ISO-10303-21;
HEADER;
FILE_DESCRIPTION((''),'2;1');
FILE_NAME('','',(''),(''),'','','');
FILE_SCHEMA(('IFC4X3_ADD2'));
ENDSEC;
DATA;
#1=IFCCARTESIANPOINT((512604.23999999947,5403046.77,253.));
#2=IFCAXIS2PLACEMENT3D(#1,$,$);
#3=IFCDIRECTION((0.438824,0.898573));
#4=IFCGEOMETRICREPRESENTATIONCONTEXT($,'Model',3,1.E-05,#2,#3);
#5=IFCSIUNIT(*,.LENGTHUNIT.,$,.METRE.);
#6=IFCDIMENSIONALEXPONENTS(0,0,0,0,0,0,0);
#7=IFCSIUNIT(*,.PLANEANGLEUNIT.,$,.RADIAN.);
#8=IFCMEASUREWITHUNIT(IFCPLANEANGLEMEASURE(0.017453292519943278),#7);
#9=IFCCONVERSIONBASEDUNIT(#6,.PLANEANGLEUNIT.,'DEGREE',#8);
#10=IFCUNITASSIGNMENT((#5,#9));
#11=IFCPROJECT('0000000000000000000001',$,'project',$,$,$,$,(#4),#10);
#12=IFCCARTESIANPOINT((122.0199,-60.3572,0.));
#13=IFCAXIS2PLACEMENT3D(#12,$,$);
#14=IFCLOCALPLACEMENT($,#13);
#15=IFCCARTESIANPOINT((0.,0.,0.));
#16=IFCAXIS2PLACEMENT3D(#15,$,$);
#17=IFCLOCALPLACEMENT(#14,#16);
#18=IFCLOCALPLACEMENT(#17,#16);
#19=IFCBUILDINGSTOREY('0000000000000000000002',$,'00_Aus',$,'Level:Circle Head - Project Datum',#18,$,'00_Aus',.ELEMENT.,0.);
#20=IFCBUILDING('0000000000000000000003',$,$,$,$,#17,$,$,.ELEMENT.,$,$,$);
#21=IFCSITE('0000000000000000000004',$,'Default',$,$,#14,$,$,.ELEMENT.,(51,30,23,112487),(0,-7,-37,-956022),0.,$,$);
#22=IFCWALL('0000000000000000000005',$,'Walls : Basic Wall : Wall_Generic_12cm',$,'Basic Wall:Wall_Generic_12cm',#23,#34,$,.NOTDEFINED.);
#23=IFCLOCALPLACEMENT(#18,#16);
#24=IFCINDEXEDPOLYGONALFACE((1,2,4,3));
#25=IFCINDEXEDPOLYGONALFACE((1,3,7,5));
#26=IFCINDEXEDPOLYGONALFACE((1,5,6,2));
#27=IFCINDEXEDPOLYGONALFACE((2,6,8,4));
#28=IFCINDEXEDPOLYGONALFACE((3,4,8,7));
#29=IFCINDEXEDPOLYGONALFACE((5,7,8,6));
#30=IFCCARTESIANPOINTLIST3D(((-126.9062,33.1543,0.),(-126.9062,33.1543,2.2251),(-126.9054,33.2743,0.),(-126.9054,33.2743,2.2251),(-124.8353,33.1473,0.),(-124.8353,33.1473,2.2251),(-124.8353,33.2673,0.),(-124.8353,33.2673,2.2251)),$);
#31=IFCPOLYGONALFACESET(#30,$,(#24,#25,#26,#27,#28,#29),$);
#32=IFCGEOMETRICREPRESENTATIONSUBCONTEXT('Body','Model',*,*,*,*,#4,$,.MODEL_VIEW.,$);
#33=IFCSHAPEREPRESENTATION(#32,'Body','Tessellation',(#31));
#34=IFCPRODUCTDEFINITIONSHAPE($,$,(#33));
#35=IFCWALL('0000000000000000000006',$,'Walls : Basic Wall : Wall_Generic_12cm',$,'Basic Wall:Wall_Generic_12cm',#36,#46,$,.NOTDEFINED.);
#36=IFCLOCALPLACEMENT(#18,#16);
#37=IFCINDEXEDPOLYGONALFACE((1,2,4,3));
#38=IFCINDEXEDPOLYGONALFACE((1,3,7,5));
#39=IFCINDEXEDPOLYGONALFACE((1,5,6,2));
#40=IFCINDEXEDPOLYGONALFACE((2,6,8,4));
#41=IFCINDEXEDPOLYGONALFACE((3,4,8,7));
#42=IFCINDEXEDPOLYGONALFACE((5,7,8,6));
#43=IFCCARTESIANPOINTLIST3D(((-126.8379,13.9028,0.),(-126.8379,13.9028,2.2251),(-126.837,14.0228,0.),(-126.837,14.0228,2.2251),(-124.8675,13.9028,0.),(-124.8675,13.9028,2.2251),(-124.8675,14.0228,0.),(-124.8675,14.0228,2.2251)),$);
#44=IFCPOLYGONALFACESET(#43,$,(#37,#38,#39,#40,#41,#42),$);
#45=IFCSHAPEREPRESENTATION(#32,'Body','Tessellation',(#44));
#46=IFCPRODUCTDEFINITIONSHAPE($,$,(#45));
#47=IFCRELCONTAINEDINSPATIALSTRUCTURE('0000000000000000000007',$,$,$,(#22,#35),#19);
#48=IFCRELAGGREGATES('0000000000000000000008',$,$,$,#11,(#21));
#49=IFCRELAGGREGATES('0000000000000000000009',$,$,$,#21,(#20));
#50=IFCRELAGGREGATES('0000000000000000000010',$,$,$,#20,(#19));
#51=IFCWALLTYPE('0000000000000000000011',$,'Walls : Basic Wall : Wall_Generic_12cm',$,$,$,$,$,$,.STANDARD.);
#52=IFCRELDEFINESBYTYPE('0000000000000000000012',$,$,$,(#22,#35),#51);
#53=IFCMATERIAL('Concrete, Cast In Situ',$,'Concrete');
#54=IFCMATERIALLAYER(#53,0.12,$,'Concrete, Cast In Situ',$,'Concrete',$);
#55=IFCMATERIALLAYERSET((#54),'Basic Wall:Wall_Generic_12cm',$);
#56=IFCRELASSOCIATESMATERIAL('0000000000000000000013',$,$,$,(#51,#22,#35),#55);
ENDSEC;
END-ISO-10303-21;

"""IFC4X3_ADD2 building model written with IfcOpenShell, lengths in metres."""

from ifc_helpers import new_model, entity, si_unit, converted_unit, direction, frame, origin, place, context, subcontext, project, spatial, polyline, outline, extrude, clip, halfspace, material, layer, layer_set, type_object, element, save


model = new_model("IFC4X3_ADD2")

# Units and contexts
model_context = context("Model", 3, precision=1e-05, world=frame((512604.23999999947, 5403046.77, 253.0)), true_north=direction((0.438824, 0.898573)))
body_context = subcontext(model_context, "Body", "Model", "MODEL_VIEW")
ifc_project = project(units=[si_unit("LENGTHUNIT", "METRE"), converted_unit("PLANEANGLEUNIT", "DEGREE", entity("IfcPlaneAngleMeasure", 0.017453292519943278), si_unit("PLANEANGLEUNIT", "RADIAN"), dimensions=[0, 0, 0, 0, 0, 0, 0])], contexts=[model_context])

# Site, building, storey
site_placement = place(None, frame((122.0199, -60.3572, 0.0)))
site = spatial("IfcSite", under=ifc_project, at=site_placement, Name="Default", CompositionType="ELEMENT", RefLatitude=(51, 30, 23, 112487), RefLongitude=(0, -7, -37, -956022), RefElevation=0.0)
building_placement = place(site_placement, origin())
building = spatial("IfcBuilding", under=site, at=building_placement, CompositionType="ELEMENT")
storey_placement = place(building_placement, origin())
storey = spatial("IfcBuildingStorey", under=building, at=storey_placement, Name="00_Aus", ObjectType="Level:Circle Head - Project Datum", LongName="00_Aus", CompositionType="ELEMENT", Elevation=0.0)

# Shared definitions
ifc_material_1 = material(Name="Concrete, Cast In Situ", Category="Concrete")

# Walls
ifc_layer_1 = layer(ifc_material_1, 0.12, Name="Concrete, Cast In Situ", Category="Concrete")
ifc_layer_set_1 = layer_set([ifc_layer_1], Name="Basic Wall:Wall_Generic_12cm")
wall_type_1 = type_object("IfcWallType", Name="Walls : Basic Wall : Wall_Generic_12cm", PredefinedType="STANDARD", material=ifc_layer_set_1)
wall_1_placement = place(storey_placement, frame((-124.8351, 33.2073, 0.0), z_axis=(0.0, 0.0, 1.0), x_axis=(-0.999994, 0.003385, 0.0)))
element("IfcWall", 1, at=wall_1_placement, inside=storey, type_object=wall_type_1, material=ifc_layer_set_1, Name="Walls : Basic Wall : Wall_Generic_12cm", ObjectType="Basic Wall:Wall_Generic_12cm", PredefinedType="NOTDEFINED", context=body_context, shape_type="Clipping", body=[
    clip(extrude(outline(polyline([(2.0705, -0.06), (2.0708, 0.06), (0.0, 0.06), (0.0004, -0.06), (2.0705, -0.06)])), origin(), (0.0, 0.0, 1.0), 2.2251), halfspace(frame((0.0, 0.0, -0.66)), True)),
])
wall_2_placement = place(storey_placement, frame((-126.8379, 13.9628, 0.0)))
element("IfcWall", 2, at=wall_2_placement, inside=storey, type_object=wall_type_1, material=ifc_layer_set_1, Name="Walls : Basic Wall : Wall_Generic_12cm", ObjectType="Basic Wall:Wall_Generic_12cm", PredefinedType="NOTDEFINED", context=body_context, shape_type="Clipping", body=[
    clip(extrude(outline(polyline([(1.9704, -0.06), (1.9704, 0.06), (1.2304, 0.06), (1.0302, 0.06), (0.0009, 0.06), (0.0002, -0.0394), (0.0, -0.06), (1.9704, -0.06)])), origin(), (0.0, 0.0, 1.0), 2.2251), halfspace(frame((0.0, 0.0, -0.66)), True)),
])

save(model, "model.ifc")
